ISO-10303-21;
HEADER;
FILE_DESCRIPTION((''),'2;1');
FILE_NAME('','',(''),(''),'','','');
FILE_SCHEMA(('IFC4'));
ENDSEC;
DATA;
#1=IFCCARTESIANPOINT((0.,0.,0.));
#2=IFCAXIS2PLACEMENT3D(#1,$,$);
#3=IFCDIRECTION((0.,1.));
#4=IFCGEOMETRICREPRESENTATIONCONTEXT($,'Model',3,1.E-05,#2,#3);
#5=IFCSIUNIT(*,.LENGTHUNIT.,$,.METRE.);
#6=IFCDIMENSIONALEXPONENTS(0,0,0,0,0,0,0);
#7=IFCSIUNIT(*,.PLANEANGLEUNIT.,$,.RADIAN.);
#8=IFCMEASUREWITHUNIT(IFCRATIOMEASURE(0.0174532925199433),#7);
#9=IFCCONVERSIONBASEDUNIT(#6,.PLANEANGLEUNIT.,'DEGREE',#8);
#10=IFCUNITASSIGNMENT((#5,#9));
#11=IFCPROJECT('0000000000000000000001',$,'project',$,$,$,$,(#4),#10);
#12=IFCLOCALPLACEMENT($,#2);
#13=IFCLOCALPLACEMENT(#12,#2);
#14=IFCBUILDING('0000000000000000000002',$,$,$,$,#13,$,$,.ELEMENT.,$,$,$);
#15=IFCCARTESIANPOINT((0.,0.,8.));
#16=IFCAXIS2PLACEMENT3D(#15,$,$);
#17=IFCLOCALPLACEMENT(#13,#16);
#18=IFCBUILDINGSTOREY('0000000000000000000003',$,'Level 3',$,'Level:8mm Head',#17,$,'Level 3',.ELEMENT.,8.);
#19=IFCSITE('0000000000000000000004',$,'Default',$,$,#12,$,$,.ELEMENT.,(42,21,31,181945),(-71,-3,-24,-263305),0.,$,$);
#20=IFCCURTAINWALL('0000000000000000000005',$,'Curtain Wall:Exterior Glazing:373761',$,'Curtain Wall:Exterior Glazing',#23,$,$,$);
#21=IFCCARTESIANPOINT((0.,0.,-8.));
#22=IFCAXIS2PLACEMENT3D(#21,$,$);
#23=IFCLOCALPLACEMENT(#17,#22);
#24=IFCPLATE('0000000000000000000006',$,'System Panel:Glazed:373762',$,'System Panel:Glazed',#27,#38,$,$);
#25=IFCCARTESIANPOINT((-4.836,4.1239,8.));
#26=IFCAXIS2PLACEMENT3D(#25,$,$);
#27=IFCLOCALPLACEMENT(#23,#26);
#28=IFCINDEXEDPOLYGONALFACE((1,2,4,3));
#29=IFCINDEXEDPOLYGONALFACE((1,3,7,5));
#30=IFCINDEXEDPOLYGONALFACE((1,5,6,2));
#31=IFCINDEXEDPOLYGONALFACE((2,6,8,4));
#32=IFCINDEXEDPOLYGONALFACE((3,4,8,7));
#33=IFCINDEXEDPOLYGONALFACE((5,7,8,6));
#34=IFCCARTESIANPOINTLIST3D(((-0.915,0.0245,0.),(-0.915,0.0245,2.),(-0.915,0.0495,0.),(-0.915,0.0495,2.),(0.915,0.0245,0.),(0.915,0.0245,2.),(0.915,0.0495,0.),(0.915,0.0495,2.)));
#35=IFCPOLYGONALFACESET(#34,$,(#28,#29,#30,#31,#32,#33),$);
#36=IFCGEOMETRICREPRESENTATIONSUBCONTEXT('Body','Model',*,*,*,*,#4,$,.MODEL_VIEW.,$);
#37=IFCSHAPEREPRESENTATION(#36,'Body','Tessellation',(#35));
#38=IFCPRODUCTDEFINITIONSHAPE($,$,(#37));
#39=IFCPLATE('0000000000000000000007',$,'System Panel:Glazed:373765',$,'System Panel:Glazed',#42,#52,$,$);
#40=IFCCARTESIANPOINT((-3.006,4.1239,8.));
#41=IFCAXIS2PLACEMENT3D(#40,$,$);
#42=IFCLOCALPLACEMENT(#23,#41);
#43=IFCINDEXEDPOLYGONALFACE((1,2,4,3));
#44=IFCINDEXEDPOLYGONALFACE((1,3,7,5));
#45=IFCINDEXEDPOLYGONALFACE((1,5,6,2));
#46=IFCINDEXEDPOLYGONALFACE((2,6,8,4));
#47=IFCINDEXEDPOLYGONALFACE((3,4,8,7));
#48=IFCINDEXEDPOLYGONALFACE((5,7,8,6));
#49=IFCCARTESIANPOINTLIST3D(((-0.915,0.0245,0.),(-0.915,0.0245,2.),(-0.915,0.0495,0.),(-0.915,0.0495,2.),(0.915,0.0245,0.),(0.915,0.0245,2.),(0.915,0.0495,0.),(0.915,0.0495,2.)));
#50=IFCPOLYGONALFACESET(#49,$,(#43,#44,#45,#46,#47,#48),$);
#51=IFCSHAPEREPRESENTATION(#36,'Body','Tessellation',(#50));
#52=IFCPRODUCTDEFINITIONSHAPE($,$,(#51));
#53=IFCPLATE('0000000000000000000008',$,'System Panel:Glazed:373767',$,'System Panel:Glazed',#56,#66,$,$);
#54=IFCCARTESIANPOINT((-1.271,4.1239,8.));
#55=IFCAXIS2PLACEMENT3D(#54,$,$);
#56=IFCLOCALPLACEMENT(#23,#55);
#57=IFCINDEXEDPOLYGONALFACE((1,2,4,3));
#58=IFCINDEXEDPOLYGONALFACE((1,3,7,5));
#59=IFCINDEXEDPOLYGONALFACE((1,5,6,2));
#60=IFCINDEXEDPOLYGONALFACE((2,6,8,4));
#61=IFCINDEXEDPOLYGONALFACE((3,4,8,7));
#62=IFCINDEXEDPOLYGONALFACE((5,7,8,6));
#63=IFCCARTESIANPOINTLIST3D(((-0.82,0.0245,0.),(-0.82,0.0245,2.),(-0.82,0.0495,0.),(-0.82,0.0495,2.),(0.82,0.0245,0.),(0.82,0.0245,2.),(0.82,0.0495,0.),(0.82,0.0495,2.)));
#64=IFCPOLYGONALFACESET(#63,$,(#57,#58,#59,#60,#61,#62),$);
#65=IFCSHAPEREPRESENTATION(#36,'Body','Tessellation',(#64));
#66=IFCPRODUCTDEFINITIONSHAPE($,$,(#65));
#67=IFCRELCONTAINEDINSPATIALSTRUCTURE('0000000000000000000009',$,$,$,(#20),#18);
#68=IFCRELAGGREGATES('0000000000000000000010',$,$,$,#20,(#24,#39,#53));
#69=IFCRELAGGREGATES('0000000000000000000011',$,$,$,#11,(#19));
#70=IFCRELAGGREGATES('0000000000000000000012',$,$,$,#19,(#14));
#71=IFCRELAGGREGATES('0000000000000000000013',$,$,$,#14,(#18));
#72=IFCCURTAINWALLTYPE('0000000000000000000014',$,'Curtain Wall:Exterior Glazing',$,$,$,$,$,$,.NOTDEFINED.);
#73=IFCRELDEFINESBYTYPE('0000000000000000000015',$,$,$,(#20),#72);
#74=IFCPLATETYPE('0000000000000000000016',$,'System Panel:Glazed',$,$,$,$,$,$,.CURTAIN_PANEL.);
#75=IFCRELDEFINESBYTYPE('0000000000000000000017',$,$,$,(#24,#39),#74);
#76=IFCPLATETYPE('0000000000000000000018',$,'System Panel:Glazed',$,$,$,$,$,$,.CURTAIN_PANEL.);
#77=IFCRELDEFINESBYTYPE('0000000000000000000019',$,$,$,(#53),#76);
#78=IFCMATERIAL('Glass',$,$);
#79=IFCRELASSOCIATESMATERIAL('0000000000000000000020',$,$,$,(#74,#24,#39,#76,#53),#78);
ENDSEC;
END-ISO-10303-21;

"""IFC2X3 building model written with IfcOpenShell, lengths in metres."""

from ifc_helpers import new_model, entity, si_unit, converted_unit, direction, frame, origin, origin_2d_with_axis, place, context, subcontext, project, spatial, rectangle, extrude, source, transform, mapped, material, type_object, type_shapes, element, aggregate, save


model = new_model("IFC2X3")

# Units and contexts
model_context = context("Model", 3, precision=1e-05, world=origin(), true_north=direction((0.0, 1.0)))
body_context = subcontext(model_context, "Body", "Model", "MODEL_VIEW")
ifc_project = project(units=[si_unit("LENGTHUNIT", "METRE"), converted_unit("PLANEANGLEUNIT", "DEGREE", entity("IfcRatioMeasure", 0.0174532925199433), si_unit("PLANEANGLEUNIT", "RADIAN"), dimensions=[0, 0, 0, 0, 0, 0, 0])], contexts=[model_context])

# Site, building, storey
site_placement = place(None, origin())
site = spatial("IfcSite", under=ifc_project, at=site_placement, Name="Default", CompositionType="ELEMENT", RefLatitude=(42, 21, 31, 181945), RefLongitude=(-71, -3, -24, -263305), RefElevation=0.0)
building_placement = place(site_placement, origin())
building = spatial("IfcBuilding", under=site, at=building_placement, CompositionType="ELEMENT")
storey_placement = place(building_placement, frame((0.0, 0.0, 8.0)))
storey = spatial("IfcBuildingStorey", under=building, at=storey_placement, Name="Level 3", ObjectType="Level:8mm Head", LongName="Level 3", CompositionType="ELEMENT", Elevation=8.0)

# Curtain wall, plates
curtain_wall_type = type_object("IfcCurtainWallType", Name="Curtain Wall:Exterior Glazing", PredefinedType="NOTDEFINED")
curtain_wall_placement = place(storey_placement, frame((0.0, 0.0, -8.0)))
curtain_wall = element("IfcCurtainWall", 1, at=curtain_wall_placement, inside=storey, type_object=curtain_wall_type, Name="Curtain Wall:Exterior Glazing:373761", ObjectType="Curtain Wall:Exterior Glazing")
ifc_material_1 = material(Name="Glass")
plate_type_1 = type_object("IfcPlateType", Name="System Panel:Glazed", PredefinedType="CURTAIN_PANEL", material=ifc_material_1)
shared_shape_1 = source(origin(), body_context, "Body", "SweptSolid", [
    extrude(rectangle(XDim=0.025, YDim=1.83, at=origin_2d_with_axis()), frame((0.0, 0.037, 0.0), z_axis=(0.0, 0.0, 1.0), x_axis=(0.0, 1.0, 0.0)), (0.0, 0.0, 1.0), 2.0),
])
type_shapes(plate_type_1, [shared_shape_1])
plate_1_placement = place(curtain_wall_placement, frame((-4.836, 4.1239, 8.0)))
plate_1 = element("IfcPlate", 2, at=plate_1_placement, type_object=plate_type_1, material=ifc_material_1, Name="System Panel:Glazed:373762", ObjectType="System Panel:Glazed", context=body_context, shape_type="MappedRepresentation", body=[
    mapped(shared_shape_1, transform((0.0, 0.0, 0.0), scale=1.0)),
])
plate_2_placement = place(curtain_wall_placement, frame((-3.006, 4.1239, 8.0)))
plate_2 = element("IfcPlate", 3, at=plate_2_placement, type_object=plate_type_1, material=ifc_material_1, Name="System Panel:Glazed:373765", ObjectType="System Panel:Glazed", context=body_context, shape_type="MappedRepresentation", body=[
    mapped(shared_shape_1, transform((0.0, 0.0, 0.0), scale=1.0)),
])
plate_type_2 = type_object("IfcPlateType", Name="System Panel:Glazed", PredefinedType="CURTAIN_PANEL", material=ifc_material_1)
shared_shape_2 = source(origin(), body_context, "Body", "SweptSolid", [
    extrude(rectangle(XDim=0.025, YDim=1.64, at=origin_2d_with_axis()), frame((0.0, 0.037, 0.0), z_axis=(0.0, 0.0, 1.0), x_axis=(0.0, 1.0, 0.0)), (0.0, 0.0, 1.0), 2.0),
])
type_shapes(plate_type_2, [shared_shape_2])
plate_3_placement = place(curtain_wall_placement, frame((-1.271, 4.1239, 8.0)))
plate_3 = element("IfcPlate", 4, at=plate_3_placement, type_object=plate_type_2, material=ifc_material_1, Name="System Panel:Glazed:373767", ObjectType="System Panel:Glazed", context=body_context, shape_type="MappedRepresentation", body=[
    mapped(shared_shape_2, transform((0.0, 0.0, 0.0), scale=1.0)),
])
aggregate(curtain_wall, [plate_1, plate_2, plate_3])

save(model, "model.ifc")
